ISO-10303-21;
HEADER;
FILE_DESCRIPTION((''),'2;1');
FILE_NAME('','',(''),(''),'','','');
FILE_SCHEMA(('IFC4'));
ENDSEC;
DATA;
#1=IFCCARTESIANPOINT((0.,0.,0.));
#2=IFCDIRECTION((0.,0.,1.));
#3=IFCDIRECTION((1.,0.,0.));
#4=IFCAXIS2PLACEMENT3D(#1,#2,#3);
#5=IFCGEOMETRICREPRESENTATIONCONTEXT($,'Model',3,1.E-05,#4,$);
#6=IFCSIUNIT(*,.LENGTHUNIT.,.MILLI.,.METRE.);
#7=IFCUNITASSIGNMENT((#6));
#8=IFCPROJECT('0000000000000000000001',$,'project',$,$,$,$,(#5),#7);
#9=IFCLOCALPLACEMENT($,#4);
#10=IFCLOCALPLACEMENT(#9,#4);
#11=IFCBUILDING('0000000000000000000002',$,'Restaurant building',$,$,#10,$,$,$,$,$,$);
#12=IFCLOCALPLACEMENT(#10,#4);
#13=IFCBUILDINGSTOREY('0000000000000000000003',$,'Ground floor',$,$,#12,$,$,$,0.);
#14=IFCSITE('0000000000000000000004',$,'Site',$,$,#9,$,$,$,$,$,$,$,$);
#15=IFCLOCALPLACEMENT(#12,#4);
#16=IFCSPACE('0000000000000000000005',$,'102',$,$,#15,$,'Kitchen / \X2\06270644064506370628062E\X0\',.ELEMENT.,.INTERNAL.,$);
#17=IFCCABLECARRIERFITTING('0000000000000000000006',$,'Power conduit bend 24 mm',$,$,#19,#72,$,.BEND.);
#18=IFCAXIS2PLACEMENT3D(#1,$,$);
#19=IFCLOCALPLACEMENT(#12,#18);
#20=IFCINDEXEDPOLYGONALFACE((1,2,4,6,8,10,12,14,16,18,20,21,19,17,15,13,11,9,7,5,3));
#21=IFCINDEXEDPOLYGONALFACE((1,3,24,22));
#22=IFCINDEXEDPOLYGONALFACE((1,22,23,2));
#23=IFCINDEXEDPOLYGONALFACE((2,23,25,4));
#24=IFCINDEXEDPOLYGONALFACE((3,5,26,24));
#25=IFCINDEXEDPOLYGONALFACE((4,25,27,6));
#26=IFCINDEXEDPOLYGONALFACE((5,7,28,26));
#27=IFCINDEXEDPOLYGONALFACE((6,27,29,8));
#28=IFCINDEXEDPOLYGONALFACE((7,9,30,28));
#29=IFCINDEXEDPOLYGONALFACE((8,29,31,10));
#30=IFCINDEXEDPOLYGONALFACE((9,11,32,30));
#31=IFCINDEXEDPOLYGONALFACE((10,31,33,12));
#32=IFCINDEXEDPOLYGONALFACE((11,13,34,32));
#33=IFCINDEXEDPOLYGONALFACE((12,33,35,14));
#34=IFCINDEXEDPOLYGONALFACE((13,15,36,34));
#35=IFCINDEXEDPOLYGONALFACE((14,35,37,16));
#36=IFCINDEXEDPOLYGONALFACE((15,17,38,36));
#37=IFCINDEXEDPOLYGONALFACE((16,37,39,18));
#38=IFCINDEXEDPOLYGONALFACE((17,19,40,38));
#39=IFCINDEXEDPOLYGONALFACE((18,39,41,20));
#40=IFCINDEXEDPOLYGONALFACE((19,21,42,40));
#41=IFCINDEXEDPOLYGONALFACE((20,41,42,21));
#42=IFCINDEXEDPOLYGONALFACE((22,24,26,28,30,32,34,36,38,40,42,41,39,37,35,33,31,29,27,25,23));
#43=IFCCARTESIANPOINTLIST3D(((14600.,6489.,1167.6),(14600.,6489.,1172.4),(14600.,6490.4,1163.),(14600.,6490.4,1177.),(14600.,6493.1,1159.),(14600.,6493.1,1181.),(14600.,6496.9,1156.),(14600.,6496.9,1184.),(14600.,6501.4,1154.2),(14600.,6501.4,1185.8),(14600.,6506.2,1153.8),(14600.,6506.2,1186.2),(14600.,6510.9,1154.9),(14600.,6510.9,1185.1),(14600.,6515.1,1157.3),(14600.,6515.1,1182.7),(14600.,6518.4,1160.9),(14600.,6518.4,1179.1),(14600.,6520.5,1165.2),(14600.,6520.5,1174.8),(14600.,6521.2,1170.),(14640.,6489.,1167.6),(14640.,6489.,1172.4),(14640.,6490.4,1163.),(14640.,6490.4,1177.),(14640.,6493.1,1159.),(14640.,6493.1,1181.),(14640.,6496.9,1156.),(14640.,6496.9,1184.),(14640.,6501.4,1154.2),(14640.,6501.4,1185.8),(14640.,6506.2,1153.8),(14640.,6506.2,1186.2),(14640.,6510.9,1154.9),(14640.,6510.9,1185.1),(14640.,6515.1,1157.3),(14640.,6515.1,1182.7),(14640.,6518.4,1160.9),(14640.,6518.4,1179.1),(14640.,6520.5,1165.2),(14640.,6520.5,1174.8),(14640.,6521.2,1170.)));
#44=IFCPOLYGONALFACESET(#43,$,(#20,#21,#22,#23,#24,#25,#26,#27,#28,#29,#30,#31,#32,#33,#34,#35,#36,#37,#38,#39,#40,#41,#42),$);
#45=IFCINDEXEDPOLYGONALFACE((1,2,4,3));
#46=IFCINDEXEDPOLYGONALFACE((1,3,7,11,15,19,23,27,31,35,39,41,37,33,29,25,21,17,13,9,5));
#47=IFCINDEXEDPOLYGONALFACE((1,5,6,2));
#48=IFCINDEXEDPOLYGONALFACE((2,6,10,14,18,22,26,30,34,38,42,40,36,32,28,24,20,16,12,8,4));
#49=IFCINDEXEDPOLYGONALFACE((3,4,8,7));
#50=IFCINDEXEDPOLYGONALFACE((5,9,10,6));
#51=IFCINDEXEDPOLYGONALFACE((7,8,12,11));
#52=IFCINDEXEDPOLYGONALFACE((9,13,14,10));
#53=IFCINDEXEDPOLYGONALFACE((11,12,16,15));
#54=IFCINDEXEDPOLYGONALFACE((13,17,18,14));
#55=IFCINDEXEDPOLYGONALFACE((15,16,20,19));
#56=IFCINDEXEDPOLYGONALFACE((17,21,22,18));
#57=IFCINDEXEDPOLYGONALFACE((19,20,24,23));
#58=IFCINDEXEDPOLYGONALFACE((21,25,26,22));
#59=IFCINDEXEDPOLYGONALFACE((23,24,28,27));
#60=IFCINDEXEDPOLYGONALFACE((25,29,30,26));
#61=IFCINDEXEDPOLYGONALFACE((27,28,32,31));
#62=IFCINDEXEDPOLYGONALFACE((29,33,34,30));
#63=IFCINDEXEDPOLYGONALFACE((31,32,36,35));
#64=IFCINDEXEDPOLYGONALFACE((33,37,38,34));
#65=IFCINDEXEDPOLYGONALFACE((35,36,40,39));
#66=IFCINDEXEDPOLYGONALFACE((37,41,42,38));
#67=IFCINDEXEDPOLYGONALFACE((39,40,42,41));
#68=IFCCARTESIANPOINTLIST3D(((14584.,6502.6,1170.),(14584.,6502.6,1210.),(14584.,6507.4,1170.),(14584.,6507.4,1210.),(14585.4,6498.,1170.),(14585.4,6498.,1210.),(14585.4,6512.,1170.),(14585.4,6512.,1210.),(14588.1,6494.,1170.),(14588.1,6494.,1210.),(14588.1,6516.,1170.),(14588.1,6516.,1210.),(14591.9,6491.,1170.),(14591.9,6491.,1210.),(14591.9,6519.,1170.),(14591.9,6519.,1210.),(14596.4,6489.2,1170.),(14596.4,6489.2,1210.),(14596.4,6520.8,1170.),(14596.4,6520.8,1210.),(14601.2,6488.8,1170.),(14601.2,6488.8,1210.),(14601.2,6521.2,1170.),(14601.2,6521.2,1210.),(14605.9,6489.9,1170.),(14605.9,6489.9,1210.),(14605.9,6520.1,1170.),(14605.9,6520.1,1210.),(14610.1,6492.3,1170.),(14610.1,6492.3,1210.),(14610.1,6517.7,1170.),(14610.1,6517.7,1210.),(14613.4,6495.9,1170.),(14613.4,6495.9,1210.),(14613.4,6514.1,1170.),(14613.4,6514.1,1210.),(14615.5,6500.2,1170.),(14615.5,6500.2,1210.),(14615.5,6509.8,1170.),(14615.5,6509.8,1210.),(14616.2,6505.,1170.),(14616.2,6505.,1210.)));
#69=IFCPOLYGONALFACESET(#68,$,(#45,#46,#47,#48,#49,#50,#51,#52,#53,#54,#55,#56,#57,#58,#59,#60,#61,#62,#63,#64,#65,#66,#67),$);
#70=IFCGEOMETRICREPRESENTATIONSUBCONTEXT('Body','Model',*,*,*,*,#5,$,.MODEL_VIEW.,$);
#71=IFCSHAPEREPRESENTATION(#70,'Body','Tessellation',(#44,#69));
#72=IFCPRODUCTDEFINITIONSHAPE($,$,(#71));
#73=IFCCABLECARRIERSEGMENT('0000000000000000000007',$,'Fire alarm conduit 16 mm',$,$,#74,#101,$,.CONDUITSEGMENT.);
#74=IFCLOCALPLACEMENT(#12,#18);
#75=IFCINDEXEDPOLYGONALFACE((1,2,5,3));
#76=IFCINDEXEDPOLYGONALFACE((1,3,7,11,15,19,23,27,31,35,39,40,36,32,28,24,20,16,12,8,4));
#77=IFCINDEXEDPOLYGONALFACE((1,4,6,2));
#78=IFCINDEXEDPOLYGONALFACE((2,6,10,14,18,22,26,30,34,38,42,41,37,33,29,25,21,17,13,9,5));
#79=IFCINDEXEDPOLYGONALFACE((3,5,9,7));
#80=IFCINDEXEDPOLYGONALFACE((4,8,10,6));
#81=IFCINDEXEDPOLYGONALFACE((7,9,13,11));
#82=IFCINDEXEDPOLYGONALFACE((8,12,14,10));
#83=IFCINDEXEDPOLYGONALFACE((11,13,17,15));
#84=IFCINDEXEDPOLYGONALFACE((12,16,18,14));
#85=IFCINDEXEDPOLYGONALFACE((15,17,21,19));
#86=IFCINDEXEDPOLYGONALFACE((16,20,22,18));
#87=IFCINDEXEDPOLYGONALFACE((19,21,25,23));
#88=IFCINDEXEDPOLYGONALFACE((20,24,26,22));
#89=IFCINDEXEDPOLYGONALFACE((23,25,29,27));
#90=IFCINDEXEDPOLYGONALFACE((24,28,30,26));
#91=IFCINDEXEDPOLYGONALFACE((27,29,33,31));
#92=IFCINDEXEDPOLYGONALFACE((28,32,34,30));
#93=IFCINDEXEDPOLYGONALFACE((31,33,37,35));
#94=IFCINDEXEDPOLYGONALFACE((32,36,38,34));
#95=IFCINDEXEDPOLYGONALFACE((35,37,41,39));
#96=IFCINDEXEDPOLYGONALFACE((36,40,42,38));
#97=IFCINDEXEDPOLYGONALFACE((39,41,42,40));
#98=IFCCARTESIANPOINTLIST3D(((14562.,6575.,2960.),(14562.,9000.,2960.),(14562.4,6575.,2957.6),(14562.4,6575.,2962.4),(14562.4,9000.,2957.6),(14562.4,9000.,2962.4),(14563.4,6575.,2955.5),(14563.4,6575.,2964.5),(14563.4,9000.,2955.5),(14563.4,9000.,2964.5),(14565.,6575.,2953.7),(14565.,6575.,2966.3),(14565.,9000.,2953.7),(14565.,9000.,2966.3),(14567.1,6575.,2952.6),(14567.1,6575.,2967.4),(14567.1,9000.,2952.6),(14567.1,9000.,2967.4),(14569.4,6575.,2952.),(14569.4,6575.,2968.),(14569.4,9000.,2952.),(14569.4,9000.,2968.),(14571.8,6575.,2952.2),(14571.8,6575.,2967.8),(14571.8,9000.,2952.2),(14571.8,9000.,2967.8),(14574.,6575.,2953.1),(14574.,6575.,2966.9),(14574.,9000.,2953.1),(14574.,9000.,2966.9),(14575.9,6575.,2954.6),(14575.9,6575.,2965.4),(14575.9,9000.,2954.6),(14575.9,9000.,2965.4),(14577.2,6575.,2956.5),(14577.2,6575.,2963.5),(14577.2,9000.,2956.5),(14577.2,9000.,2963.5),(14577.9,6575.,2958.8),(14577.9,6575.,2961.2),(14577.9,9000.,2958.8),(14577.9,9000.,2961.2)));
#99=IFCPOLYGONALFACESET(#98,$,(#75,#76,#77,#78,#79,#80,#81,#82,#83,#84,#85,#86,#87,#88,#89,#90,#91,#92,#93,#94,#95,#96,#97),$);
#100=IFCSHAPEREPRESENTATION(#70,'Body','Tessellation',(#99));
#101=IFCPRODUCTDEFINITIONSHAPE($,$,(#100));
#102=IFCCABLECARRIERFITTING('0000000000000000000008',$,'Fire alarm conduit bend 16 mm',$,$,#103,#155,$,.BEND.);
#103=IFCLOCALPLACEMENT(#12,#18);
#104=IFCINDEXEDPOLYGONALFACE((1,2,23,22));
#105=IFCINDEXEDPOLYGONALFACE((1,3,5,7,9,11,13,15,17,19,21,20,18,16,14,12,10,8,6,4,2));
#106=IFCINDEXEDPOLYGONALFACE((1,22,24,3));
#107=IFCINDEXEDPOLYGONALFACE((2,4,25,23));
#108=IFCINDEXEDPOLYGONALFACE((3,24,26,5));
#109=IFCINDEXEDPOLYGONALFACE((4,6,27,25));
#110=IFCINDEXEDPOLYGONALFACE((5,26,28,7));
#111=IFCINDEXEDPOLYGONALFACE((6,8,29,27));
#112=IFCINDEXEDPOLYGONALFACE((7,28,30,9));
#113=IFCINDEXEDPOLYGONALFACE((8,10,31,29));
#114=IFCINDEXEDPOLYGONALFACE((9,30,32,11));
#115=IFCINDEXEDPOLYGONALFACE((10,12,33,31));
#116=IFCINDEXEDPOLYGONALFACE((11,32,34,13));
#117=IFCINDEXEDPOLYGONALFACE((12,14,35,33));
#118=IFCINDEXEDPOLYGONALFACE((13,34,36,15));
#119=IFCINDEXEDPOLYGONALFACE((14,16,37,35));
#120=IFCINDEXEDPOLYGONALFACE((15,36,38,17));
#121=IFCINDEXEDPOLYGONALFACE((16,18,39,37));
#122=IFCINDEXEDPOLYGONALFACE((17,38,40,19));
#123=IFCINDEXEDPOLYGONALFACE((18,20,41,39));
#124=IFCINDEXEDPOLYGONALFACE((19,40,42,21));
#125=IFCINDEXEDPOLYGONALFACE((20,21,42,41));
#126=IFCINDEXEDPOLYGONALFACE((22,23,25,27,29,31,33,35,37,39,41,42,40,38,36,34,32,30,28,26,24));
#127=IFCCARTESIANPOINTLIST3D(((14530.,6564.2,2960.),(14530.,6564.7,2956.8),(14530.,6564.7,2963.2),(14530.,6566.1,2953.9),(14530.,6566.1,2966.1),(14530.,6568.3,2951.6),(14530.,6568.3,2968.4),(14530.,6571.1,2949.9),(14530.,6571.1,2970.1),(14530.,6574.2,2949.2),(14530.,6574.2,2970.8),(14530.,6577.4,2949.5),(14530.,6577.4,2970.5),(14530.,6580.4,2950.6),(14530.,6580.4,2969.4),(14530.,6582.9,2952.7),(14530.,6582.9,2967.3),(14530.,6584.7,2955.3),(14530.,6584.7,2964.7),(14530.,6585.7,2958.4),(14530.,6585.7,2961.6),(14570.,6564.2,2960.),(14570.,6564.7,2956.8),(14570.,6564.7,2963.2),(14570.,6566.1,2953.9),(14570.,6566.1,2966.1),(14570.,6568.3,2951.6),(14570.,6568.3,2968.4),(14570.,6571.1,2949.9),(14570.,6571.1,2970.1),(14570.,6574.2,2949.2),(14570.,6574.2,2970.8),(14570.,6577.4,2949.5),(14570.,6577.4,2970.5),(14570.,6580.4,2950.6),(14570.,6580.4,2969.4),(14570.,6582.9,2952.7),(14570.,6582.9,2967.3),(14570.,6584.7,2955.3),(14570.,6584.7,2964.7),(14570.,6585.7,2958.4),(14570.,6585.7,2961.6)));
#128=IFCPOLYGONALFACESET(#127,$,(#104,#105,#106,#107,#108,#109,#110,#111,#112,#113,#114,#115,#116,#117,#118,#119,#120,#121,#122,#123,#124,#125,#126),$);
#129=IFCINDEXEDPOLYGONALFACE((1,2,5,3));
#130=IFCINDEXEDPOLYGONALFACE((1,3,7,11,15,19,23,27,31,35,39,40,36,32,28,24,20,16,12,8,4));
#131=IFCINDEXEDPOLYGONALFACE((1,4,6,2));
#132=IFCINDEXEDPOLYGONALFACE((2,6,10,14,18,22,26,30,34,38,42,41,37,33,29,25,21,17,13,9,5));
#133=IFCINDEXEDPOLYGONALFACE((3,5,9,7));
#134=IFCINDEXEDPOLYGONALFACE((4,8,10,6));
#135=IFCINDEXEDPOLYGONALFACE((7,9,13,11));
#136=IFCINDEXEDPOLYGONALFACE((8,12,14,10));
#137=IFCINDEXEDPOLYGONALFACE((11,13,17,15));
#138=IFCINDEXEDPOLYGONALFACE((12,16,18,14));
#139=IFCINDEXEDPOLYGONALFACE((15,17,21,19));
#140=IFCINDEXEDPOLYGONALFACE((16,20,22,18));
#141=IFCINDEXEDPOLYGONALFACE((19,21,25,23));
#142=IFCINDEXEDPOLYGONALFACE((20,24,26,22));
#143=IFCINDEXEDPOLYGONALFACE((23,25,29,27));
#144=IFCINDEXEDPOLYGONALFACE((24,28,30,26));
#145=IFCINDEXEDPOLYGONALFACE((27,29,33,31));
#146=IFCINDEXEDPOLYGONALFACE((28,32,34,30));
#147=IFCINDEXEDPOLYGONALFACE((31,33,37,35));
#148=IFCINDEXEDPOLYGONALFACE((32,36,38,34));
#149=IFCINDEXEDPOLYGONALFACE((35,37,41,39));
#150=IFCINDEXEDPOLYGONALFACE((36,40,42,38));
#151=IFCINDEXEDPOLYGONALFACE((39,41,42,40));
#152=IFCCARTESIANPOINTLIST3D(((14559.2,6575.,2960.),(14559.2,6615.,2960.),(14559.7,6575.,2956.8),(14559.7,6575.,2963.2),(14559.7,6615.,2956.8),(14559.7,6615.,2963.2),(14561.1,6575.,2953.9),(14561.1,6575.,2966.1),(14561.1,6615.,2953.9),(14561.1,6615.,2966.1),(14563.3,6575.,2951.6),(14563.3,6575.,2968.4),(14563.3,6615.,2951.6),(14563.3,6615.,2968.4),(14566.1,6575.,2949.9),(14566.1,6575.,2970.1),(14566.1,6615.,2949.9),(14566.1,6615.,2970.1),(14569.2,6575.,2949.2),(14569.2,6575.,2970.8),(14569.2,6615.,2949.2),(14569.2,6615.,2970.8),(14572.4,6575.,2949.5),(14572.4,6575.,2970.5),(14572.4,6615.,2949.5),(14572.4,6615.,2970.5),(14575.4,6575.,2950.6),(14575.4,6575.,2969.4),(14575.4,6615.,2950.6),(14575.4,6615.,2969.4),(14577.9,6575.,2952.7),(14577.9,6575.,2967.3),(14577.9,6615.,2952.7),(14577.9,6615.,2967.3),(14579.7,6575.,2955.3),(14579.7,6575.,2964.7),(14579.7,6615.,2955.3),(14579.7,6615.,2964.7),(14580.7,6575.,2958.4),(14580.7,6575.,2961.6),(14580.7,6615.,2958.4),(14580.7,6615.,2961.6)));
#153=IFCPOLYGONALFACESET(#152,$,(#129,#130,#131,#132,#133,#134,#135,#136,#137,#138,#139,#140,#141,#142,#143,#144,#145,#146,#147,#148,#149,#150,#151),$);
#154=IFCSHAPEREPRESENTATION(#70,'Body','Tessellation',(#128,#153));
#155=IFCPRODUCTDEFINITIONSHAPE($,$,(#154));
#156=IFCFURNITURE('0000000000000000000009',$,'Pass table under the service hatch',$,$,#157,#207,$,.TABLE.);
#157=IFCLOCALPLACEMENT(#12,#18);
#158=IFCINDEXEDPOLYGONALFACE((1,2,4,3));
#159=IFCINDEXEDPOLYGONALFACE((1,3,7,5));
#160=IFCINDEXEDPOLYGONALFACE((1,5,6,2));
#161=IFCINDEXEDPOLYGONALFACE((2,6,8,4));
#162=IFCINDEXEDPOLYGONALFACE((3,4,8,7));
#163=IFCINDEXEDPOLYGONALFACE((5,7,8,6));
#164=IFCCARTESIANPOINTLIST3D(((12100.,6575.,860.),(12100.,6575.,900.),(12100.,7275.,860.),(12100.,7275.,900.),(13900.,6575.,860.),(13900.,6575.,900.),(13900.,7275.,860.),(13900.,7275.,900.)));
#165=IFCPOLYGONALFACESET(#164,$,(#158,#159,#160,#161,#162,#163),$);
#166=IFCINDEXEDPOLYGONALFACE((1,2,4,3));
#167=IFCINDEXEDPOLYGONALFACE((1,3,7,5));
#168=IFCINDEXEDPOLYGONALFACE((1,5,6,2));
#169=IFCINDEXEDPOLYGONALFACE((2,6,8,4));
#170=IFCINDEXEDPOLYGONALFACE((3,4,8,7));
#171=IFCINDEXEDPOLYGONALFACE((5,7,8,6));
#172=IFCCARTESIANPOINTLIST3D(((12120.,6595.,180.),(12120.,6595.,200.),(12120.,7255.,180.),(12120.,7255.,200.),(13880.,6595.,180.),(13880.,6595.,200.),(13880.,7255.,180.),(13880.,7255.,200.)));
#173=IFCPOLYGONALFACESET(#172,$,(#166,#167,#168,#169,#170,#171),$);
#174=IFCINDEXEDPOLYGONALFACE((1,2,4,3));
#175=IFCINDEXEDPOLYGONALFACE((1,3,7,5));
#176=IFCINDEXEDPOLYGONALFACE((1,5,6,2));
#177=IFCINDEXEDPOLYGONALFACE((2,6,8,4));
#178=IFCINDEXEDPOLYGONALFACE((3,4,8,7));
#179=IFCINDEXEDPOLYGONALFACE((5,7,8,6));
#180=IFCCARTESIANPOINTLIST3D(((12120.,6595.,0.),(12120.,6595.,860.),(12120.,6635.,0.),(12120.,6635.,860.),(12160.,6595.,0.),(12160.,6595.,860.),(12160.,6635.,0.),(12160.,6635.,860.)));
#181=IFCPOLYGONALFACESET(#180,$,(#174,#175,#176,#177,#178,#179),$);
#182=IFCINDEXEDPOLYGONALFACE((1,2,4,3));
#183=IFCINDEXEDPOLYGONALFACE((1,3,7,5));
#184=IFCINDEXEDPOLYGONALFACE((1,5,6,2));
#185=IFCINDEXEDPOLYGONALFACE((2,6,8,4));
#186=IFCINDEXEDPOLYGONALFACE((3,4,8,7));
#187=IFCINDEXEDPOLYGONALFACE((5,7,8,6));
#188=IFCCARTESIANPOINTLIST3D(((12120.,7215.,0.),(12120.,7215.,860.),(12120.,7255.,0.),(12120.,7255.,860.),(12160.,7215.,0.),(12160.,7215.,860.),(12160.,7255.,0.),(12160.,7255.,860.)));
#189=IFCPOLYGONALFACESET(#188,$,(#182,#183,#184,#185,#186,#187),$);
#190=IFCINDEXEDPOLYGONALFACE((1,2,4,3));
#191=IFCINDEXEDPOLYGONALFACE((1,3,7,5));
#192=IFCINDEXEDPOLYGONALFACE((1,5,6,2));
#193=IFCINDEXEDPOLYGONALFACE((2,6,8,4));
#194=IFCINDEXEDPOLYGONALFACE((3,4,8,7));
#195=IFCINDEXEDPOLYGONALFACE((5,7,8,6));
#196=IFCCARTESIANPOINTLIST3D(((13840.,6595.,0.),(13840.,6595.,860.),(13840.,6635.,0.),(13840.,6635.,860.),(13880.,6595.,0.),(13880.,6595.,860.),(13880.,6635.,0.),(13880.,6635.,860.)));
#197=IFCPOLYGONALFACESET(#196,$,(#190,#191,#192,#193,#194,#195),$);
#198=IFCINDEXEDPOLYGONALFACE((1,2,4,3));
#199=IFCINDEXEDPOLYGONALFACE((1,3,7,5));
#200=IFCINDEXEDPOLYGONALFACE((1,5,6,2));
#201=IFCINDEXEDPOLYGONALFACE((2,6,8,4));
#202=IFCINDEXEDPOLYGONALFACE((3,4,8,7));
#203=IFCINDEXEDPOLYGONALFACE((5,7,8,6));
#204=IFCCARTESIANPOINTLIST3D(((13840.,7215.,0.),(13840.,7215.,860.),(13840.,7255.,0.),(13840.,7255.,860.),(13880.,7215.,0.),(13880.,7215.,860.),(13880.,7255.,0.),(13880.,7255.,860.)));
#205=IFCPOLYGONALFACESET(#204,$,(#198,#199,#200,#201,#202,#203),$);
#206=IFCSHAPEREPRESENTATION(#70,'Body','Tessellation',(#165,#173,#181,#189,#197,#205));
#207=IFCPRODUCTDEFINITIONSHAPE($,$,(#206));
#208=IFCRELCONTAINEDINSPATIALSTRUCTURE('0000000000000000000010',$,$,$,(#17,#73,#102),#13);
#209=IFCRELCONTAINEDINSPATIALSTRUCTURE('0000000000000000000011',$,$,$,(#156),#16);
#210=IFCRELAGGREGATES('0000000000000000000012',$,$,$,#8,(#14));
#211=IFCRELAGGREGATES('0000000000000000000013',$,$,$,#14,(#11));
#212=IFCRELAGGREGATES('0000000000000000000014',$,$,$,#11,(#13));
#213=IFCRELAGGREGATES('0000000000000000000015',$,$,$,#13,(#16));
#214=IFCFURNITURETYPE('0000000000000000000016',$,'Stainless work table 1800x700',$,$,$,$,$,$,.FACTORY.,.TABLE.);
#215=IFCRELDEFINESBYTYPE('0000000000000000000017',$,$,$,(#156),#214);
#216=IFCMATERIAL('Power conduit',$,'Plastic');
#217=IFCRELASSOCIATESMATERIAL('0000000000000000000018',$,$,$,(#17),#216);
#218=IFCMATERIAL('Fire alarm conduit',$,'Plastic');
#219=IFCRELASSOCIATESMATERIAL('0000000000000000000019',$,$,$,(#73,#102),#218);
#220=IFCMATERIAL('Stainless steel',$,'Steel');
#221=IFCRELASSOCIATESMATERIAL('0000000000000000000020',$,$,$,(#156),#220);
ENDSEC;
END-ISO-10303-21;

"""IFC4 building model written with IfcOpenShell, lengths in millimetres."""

from ifc_helpers import new_model, si_unit, frame, origin, origin_with_axes, origin_2d, place, context, subcontext, project, spatial, rectangle, circle, extrude, source, transform, mapped, material, type_object, type_shapes, element, save


model = new_model("IFC4")

# Units and contexts
model_context = context("Model", 3, precision=1e-05, world=origin_with_axes())
body_context = subcontext(model_context, "Body", "Model", "MODEL_VIEW")
ifc_project = project(units=[si_unit("LENGTHUNIT", "METRE", prefix="MILLI")], contexts=[model_context])

# Site, building, storey
site_placement = place(None, origin_with_axes())
site = spatial("IfcSite", under=ifc_project, at=site_placement, Name="Site")
building_placement = place(site_placement, origin_with_axes())
building = spatial("IfcBuilding", under=site, at=building_placement, Name="Restaurant building")
storey_placement = place(building_placement, origin_with_axes())
storey = spatial("IfcBuildingStorey", under=building, at=storey_placement, Name="Ground floor", Elevation=0.0)

# Shared definitions
space_1_placement = place(storey_placement, origin_with_axes())
space_1 = spatial("IfcSpace", under=storey, at=space_1_placement, Name="102", LongName="Kitchen / المطبخ", CompositionType="ELEMENT", PredefinedType="INTERNAL")

# Shared definitions
ifc_material_1 = material(Name="Power conduit", Category="Plastic")

# Cable carrier fitting
cable_carrier_fitting_1_placement = place(storey_placement, frame((14600.0, 6505.0, 1170.0)))
element("IfcCableCarrierFitting", 1, at=cable_carrier_fitting_1_placement, inside=storey, material=ifc_material_1, Name="Power conduit bend 24 mm", PredefinedType="BEND", context=body_context, shape_type="SweptSolid", body=[
    extrude(circle(Radius=16.2, at=origin_2d()), frame((0.0, 0.0, 0.0), z_axis=(1.0, 0.0, 0.0), x_axis=(0.0, 1.0, 0.0)), (0.0, 0.0, 1.0), 40.0),
    extrude(circle(Radius=16.2, at=origin_2d()), origin(), (0.0, 0.0, 1.0), 40.0),
])

# Cable carrier segment
ifc_material_2 = material(Name="Fire alarm conduit", Category="Plastic")
cable_carrier_segment_1_placement = place(storey_placement, frame((14570.0, 6575.0, 2960.0)))
element("IfcCableCarrierSegment", 2, at=cable_carrier_segment_1_placement, inside=storey, material=ifc_material_2, Name="Fire alarm conduit 16 mm", PredefinedType="CONDUITSEGMENT", context=body_context, shape_type="SweptSolid", body=[
    extrude(circle(Radius=8.0, at=origin_2d()), frame((0.0, 0.0, 0.0), z_axis=(0.0, 1.0, 0.0), x_axis=(-1.0, 0.0, 0.0)), (0.0, 0.0, 1.0), 2425.0),
])

# Cable carrier fitting
cable_carrier_fitting_2_placement = place(storey_placement, frame((14570.0, 6575.0, 2960.0)))
element("IfcCableCarrierFitting", 3, at=cable_carrier_fitting_2_placement, inside=storey, material=ifc_material_2, Name="Fire alarm conduit bend 16 mm", PredefinedType="BEND", context=body_context, shape_type="SweptSolid", body=[
    extrude(circle(Radius=10.8, at=origin_2d()), frame((0.0, 0.0, 0.0), z_axis=(-1.0, 0.0, 0.0), x_axis=(0.0, -1.0, 0.0)), (0.0, 0.0, 1.0), 40.0),
    extrude(circle(Radius=10.8, at=origin_2d()), frame((0.0, 0.0, 0.0), z_axis=(0.0, 1.0, 0.0), x_axis=(-1.0, 0.0, 0.0)), (0.0, 0.0, 1.0), 40.0),
])

# Furniture
ifc_material_3 = material(Name="Stainless steel", Category="Steel")
furniture_type = type_object("IfcFurnitureType", Name="Stainless work table 1800x700", AssemblyPlace="FACTORY", PredefinedType="TABLE")
shared_shape_1 = source(origin(), body_context, "Body", "SweptSolid", [
    extrude(rectangle(XDim=1800.0, YDim=700.0, at=origin_2d()), frame((0.0, 0.0, 860.0)), (0.0, 0.0, 1.0), 40.0),
    extrude(rectangle(XDim=1760.0, YDim=660.0, at=origin_2d()), frame((0.0, 0.0, 180.0)), (0.0, 0.0, 1.0), 20.0),
    extrude(rectangle(XDim=40.0, YDim=40.0, at=origin_2d()), frame((-860.0, -310.0, 0.0)), (0.0, 0.0, 1.0), 860.0),
    extrude(rectangle(XDim=40.0, YDim=40.0, at=origin_2d()), frame((-860.0, 310.0, 0.0)), (0.0, 0.0, 1.0), 860.0),
    extrude(rectangle(XDim=40.0, YDim=40.0, at=origin_2d()), frame((860.0, -310.0, 0.0)), (0.0, 0.0, 1.0), 860.0),
    extrude(rectangle(XDim=40.0, YDim=40.0, at=origin_2d()), frame((860.0, 310.0, 0.0)), (0.0, 0.0, 1.0), 860.0),
])
type_shapes(furniture_type, [shared_shape_1])
furniture_placement = place(storey_placement, frame((13000.0, 6925.0, 0.0)))
element("IfcFurniture", 4, at=furniture_placement, inside=space_1, type_object=furniture_type, material=ifc_material_3, Name="Pass table under the service hatch", PredefinedType="TABLE", context=body_context, shape_type="MappedRepresentation", body=[
    mapped(shared_shape_1, transform((0.0, 0.0, 0.0))),
])

save(model, "model.ifc")
